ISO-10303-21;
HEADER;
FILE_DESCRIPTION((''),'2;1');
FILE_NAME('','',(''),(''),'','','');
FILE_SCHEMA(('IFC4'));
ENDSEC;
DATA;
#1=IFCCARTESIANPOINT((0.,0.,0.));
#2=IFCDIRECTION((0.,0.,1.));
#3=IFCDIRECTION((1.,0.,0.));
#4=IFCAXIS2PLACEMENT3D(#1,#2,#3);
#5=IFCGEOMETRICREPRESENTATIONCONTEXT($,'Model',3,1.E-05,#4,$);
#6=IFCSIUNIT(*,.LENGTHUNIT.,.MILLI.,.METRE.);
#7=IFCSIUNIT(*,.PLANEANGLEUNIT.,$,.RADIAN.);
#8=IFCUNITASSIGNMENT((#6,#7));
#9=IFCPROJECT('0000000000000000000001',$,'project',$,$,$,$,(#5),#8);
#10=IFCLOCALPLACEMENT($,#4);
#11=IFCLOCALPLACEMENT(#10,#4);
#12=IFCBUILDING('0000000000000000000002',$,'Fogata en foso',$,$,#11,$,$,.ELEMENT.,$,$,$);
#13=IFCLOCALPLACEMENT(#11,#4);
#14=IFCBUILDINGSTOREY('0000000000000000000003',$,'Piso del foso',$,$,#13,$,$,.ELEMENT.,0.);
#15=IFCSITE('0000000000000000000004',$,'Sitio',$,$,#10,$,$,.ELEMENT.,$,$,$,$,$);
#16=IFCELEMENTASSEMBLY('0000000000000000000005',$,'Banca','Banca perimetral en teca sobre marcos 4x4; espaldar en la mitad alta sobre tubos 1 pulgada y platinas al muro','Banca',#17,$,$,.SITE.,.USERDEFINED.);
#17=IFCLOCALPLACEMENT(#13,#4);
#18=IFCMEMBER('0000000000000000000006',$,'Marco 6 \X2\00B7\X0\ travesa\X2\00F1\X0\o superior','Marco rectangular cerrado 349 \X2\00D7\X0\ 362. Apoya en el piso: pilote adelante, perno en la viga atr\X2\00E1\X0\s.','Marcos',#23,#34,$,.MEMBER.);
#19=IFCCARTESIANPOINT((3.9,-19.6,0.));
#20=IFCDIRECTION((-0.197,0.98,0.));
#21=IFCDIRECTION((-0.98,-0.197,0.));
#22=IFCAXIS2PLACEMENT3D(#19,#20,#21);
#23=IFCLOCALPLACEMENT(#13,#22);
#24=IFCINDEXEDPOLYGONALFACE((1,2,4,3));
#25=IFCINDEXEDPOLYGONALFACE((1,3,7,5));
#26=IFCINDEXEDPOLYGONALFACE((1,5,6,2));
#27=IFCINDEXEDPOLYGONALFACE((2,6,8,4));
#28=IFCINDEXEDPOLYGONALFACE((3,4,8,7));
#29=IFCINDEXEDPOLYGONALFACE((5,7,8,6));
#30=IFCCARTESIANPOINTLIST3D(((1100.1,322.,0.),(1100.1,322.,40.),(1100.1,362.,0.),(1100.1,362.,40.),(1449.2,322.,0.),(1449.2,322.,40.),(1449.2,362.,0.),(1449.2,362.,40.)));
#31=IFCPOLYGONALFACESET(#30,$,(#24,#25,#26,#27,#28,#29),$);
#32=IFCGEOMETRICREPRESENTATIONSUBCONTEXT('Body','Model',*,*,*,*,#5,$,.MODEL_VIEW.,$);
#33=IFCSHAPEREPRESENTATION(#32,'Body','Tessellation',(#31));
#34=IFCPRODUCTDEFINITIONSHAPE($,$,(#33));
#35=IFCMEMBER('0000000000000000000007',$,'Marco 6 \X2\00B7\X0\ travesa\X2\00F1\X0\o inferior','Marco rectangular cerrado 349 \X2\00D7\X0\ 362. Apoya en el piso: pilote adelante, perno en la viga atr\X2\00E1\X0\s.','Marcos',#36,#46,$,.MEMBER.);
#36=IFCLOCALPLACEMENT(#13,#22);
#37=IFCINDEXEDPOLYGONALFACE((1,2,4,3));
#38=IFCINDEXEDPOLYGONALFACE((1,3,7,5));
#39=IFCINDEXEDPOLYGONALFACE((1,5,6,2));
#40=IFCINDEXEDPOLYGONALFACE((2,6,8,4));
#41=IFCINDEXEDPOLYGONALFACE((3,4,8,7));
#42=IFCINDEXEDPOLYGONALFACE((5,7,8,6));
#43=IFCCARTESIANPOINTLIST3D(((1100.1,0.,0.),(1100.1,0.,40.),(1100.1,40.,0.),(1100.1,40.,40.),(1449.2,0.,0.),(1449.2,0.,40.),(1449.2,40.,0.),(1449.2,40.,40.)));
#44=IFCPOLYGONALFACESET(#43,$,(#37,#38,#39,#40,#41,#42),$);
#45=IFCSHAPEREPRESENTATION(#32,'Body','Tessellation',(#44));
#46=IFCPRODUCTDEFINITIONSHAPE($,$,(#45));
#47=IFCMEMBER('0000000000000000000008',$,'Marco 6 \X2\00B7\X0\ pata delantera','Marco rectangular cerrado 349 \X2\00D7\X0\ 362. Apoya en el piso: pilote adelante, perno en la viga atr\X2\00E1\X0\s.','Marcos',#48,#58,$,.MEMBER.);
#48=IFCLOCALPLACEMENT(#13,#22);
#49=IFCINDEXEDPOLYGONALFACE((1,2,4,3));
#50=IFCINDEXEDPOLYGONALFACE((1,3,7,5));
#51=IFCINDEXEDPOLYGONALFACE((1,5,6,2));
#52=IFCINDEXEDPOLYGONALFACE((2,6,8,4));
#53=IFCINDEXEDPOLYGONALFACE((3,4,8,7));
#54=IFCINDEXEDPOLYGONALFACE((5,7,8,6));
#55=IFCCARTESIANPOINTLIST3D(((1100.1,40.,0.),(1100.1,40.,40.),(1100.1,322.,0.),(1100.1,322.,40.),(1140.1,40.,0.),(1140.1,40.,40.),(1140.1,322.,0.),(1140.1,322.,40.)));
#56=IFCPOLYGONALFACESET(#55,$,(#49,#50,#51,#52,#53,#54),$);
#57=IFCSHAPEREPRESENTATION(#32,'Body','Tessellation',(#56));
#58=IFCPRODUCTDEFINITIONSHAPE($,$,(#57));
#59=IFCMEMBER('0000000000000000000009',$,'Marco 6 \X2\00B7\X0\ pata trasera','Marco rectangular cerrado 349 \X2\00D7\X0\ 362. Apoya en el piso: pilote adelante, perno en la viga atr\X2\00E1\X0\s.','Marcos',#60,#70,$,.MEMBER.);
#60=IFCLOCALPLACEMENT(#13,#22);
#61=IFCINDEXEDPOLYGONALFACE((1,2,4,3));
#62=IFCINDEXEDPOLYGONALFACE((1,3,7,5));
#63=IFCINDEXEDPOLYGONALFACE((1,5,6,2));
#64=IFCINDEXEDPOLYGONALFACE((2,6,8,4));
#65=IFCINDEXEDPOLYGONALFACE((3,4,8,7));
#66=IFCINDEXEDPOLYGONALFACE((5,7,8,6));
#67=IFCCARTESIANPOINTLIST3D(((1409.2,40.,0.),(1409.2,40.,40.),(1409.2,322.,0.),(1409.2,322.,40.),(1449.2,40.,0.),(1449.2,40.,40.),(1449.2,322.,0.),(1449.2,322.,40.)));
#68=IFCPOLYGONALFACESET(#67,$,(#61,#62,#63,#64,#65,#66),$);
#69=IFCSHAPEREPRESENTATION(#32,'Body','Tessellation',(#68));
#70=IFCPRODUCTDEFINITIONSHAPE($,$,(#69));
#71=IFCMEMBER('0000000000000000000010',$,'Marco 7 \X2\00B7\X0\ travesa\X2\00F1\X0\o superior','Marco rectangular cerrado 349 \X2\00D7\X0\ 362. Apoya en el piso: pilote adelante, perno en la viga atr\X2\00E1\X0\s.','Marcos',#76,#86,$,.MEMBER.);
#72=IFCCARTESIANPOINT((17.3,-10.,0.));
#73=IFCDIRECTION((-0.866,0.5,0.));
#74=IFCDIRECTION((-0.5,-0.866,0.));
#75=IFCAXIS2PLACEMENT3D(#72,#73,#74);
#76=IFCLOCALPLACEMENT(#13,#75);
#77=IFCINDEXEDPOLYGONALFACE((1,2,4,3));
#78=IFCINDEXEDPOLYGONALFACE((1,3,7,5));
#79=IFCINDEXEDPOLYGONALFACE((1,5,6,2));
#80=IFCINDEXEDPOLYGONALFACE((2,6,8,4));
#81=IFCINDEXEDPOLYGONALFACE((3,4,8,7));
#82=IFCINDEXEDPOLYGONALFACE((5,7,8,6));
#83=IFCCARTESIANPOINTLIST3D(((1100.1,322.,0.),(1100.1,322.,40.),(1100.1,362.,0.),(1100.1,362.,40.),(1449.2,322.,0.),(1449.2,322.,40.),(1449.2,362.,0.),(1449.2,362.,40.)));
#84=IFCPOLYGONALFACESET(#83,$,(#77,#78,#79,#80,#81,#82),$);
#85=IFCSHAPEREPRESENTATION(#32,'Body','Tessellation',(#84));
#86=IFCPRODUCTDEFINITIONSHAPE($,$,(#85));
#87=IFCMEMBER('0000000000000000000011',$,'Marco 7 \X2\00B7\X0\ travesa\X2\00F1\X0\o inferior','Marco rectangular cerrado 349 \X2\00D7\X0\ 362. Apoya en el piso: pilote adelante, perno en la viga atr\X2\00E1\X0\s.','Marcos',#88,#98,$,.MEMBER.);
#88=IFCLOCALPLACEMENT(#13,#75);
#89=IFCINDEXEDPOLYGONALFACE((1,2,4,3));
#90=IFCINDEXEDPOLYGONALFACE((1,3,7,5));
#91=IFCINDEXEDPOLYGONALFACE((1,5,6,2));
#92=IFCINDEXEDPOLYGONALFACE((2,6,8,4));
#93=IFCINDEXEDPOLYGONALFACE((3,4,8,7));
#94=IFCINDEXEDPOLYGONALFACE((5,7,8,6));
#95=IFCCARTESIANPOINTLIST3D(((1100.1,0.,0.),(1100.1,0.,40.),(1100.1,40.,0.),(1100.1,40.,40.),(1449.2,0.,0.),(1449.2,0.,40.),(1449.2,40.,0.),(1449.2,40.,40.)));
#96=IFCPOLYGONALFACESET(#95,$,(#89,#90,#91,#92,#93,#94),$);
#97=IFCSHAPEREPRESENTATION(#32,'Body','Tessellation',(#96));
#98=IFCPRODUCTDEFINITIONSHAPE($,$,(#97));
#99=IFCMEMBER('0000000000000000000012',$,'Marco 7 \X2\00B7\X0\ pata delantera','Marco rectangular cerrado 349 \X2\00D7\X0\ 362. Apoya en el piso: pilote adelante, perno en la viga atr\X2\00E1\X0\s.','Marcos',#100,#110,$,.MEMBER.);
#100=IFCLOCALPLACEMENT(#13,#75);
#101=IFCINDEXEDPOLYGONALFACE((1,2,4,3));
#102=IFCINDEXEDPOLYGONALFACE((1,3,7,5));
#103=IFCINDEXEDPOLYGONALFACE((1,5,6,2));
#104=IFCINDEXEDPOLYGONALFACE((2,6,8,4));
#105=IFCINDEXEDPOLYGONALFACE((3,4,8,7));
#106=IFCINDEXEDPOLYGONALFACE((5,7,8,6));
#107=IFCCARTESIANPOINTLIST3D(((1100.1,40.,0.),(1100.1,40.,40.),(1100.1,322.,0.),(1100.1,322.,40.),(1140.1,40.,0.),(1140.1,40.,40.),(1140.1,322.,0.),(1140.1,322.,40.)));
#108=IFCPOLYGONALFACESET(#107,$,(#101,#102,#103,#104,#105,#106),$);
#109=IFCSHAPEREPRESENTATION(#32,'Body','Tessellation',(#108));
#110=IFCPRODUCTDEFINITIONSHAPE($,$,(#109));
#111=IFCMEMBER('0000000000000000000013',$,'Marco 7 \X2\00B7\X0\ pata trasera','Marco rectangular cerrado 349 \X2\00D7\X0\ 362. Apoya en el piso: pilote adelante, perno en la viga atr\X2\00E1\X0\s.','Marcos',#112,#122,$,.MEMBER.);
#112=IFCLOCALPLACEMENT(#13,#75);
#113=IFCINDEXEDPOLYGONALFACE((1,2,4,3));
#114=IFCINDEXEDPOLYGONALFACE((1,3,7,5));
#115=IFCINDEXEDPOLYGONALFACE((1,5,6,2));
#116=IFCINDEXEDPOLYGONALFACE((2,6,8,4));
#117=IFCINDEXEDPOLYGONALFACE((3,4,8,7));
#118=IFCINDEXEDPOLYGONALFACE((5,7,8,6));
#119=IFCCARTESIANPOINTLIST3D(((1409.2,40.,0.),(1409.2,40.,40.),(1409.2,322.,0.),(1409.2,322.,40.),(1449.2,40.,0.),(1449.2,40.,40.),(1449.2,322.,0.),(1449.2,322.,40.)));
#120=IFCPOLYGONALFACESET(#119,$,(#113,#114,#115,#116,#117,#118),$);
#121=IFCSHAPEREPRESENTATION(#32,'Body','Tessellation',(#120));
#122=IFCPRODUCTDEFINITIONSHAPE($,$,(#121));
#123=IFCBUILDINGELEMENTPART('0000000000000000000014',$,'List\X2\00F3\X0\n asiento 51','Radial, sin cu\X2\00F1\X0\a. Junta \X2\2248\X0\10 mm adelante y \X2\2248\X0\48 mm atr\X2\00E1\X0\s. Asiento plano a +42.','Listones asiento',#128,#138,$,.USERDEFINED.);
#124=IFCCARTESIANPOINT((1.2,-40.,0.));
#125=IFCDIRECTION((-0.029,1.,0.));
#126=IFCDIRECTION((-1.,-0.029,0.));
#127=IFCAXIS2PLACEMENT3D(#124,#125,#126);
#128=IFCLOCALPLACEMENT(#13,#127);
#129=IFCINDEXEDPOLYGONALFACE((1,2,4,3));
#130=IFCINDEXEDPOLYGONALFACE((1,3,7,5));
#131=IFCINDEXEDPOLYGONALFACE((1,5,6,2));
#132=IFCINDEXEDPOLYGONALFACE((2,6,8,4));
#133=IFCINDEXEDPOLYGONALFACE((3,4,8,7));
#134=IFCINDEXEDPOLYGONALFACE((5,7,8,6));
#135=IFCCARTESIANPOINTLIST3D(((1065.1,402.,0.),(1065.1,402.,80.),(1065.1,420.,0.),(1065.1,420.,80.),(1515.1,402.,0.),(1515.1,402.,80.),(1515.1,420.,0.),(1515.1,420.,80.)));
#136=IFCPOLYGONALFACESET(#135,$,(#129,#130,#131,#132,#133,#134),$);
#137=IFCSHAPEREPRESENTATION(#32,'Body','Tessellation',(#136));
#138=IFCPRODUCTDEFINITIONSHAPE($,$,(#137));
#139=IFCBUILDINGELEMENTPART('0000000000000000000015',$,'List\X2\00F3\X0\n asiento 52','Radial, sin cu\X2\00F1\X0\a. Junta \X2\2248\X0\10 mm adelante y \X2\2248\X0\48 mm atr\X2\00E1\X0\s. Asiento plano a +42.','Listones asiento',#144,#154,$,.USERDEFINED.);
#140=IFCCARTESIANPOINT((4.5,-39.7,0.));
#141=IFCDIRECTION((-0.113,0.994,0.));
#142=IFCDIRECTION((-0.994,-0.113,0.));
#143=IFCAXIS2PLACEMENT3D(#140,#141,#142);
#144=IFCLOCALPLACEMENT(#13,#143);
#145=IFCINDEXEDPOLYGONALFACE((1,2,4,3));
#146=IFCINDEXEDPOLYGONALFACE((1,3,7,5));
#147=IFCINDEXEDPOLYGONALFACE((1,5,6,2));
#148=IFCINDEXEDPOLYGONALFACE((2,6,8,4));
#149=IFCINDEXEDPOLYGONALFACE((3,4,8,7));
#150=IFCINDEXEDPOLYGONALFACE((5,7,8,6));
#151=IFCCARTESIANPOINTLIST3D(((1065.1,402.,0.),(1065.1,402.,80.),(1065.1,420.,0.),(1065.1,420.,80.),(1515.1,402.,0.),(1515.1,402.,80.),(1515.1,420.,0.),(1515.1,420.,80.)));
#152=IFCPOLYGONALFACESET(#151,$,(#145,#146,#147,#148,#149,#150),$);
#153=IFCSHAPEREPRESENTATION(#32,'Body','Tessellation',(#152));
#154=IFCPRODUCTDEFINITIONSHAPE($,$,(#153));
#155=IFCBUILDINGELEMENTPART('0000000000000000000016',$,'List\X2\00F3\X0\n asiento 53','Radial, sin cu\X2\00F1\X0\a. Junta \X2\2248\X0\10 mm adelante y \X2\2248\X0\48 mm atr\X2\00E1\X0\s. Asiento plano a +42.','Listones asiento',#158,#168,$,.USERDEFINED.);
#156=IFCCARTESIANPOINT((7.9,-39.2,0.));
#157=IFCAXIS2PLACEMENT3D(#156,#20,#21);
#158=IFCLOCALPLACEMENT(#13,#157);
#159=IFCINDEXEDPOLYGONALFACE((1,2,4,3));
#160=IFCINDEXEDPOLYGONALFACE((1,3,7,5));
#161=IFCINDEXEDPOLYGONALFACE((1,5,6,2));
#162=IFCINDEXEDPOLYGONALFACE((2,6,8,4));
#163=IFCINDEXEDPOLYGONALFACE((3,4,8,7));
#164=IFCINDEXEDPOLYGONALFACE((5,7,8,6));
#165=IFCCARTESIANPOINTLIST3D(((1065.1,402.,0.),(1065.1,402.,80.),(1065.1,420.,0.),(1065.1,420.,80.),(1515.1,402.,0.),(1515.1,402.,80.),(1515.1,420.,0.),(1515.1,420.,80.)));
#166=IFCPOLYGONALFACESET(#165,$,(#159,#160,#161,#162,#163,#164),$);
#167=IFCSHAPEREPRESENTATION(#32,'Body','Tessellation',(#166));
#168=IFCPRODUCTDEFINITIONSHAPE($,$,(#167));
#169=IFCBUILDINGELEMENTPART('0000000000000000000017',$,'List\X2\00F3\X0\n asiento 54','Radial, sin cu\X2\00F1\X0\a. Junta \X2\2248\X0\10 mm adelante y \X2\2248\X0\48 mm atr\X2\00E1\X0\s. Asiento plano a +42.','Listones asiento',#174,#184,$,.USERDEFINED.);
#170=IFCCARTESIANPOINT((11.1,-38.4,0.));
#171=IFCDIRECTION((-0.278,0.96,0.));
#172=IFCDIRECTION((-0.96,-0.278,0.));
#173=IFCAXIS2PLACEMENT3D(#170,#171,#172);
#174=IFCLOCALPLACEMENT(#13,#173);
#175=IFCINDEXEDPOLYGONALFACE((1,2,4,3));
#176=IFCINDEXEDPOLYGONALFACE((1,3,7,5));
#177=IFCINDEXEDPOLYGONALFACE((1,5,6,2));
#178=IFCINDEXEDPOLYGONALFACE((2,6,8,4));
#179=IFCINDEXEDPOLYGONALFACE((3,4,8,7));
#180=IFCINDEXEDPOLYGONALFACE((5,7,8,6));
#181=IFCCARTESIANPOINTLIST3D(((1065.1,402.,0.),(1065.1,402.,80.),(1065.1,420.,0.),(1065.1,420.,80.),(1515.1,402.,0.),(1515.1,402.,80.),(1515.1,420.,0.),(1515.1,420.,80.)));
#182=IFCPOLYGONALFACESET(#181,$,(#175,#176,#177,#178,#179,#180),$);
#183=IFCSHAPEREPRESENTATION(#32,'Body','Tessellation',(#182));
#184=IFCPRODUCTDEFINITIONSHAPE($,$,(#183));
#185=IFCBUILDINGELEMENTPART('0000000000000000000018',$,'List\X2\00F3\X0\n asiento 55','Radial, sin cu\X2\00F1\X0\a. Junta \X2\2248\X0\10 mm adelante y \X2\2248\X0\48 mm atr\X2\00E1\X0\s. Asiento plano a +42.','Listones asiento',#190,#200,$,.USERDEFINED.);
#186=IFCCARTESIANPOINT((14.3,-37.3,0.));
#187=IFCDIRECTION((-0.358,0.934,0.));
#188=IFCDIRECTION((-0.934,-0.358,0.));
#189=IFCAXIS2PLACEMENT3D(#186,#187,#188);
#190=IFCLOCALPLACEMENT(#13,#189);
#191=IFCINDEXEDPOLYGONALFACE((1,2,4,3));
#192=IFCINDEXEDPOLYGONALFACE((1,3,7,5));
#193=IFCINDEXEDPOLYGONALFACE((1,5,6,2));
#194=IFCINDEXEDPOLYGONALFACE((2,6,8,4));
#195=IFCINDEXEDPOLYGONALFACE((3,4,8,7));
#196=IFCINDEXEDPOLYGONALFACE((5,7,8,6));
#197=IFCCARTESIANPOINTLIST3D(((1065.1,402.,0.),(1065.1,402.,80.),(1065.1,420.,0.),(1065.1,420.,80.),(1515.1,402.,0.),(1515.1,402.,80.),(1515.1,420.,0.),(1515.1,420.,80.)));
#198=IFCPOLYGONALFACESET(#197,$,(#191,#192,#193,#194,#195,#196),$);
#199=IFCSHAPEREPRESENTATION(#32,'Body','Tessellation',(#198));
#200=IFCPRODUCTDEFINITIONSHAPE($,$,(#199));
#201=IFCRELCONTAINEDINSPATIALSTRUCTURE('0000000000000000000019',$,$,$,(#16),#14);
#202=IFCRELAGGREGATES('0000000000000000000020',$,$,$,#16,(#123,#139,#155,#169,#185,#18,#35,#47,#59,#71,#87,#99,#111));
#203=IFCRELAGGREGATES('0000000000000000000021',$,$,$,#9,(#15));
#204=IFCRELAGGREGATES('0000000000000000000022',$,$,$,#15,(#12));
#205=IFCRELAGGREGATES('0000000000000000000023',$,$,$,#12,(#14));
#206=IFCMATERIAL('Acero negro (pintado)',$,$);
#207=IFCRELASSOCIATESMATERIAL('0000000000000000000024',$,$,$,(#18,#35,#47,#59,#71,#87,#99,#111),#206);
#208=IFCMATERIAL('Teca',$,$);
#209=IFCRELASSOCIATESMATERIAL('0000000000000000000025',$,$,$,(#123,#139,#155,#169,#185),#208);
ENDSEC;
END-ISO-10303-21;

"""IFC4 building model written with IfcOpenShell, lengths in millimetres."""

from ifc_helpers import new_model, si_unit, frame, origin_with_axes, place, context, subcontext, project, spatial, polyline, outline, extrude, material, element, aggregate, save


model = new_model("IFC4")

# Units and contexts
model_context = context("Model", 3, precision=1e-05, world=origin_with_axes())
body_context = subcontext(model_context, "Body", "Model", "MODEL_VIEW")
ifc_project = project(units=[si_unit("LENGTHUNIT", "METRE", prefix="MILLI"), si_unit("PLANEANGLEUNIT", "RADIAN")], contexts=[model_context])

# Site, building, storey
site_placement = place(None, origin_with_axes())
site = spatial("IfcSite", under=ifc_project, at=site_placement, Name="Sitio", CompositionType="ELEMENT")
building_placement = place(site_placement, origin_with_axes())
building = spatial("IfcBuilding", under=site, at=building_placement, Name="Fogata en foso", CompositionType="ELEMENT")
storey_placement = place(building_placement, origin_with_axes())
storey = spatial("IfcBuildingStorey", under=building, at=storey_placement, Name="Piso del foso", CompositionType="ELEMENT", Elevation=0.0)

# Element assembly, members, building element parts
assembly_1_placement = place(storey_placement, origin_with_axes())
assembly_1 = element("IfcElementAssembly", 1, at=assembly_1_placement, inside=storey, Name="Banca", Description="Banca perimetral en teca sobre marcos 4x4; espaldar en la mitad alta sobre tubos 1 pulgada y platinas al muro", ObjectType="Banca", AssemblyPlace="SITE", PredefinedType="USERDEFINED")
ifc_material_1 = material(Name="Acero negro (pintado)")
member_1_placement = place(storey_placement, frame((3.9, -19.6, 0.0), z_axis=(-0.197, 0.98, 0.0), x_axis=(-0.98, -0.197, 0.0)))
member_1 = element("IfcMember", 2, at=member_1_placement, material=ifc_material_1, Name="Marco 6 · travesaño superior", Description="Marco rectangular cerrado 349 × 362. Apoya en el piso: pilote adelante, perno en la viga atrás.", ObjectType="Marcos", PredefinedType="MEMBER", context=body_context, shape_type="SweptSolid", body=[
    extrude(outline(polyline([(1100.1, 322.0), (1449.2, 322.0), (1449.2, 362.0), (1100.1, 362.0), (1100.1, 322.0)])), origin_with_axes(), (0.0, 0.0, 1.0), 40.0),
])
member_2_placement = place(storey_placement, frame((3.9, -19.6, 0.0), z_axis=(-0.197, 0.98, 0.0), x_axis=(-0.98, -0.197, 0.0)))
member_2 = element("IfcMember", 3, at=member_2_placement, material=ifc_material_1, Name="Marco 6 · travesaño inferior", Description="Marco rectangular cerrado 349 × 362. Apoya en el piso: pilote adelante, perno en la viga atrás.", ObjectType="Marcos", PredefinedType="MEMBER", context=body_context, shape_type="SweptSolid", body=[
    extrude(outline(polyline([(1100.1, 0.0), (1449.2, 0.0), (1449.2, 40.0), (1100.1, 40.0), (1100.1, 0.0)])), origin_with_axes(), (0.0, 0.0, 1.0), 40.0),
])
member_3_placement = place(storey_placement, frame((3.9, -19.6, 0.0), z_axis=(-0.197, 0.98, 0.0), x_axis=(-0.98, -0.197, 0.0)))
member_3 = element("IfcMember", 4, at=member_3_placement, material=ifc_material_1, Name="Marco 6 · pata delantera", Description="Marco rectangular cerrado 349 × 362. Apoya en el piso: pilote adelante, perno en la viga atrás.", ObjectType="Marcos", PredefinedType="MEMBER", context=body_context, shape_type="SweptSolid", body=[
    extrude(outline(polyline([(1100.1, 40.0), (1140.1, 40.0), (1140.1, 322.0), (1100.1, 322.0), (1100.1, 40.0)])), origin_with_axes(), (0.0, 0.0, 1.0), 40.0),
])
member_4_placement = place(storey_placement, frame((3.9, -19.6, 0.0), z_axis=(-0.197, 0.98, 0.0), x_axis=(-0.98, -0.197, 0.0)))
member_4 = element("IfcMember", 5, at=member_4_placement, material=ifc_material_1, Name="Marco 6 · pata trasera", Description="Marco rectangular cerrado 349 × 362. Apoya en el piso: pilote adelante, perno en la viga atrás.", ObjectType="Marcos", PredefinedType="MEMBER", context=body_context, shape_type="SweptSolid", body=[
    extrude(outline(polyline([(1409.2, 40.0), (1449.2, 40.0), (1449.2, 322.0), (1409.2, 322.0), (1409.2, 40.0)])), origin_with_axes(), (0.0, 0.0, 1.0), 40.0),
])
member_5_placement = place(storey_placement, frame((17.3, -10.0, 0.0), z_axis=(-0.866, 0.5, 0.0), x_axis=(-0.5, -0.866, 0.0)))
member_5 = element("IfcMember", 6, at=member_5_placement, material=ifc_material_1, Name="Marco 7 · travesaño superior", Description="Marco rectangular cerrado 349 × 362. Apoya en el piso: pilote adelante, perno en la viga atrás.", ObjectType="Marcos", PredefinedType="MEMBER", context=body_context, shape_type="SweptSolid", body=[
    extrude(outline(polyline([(1100.1, 322.0), (1449.2, 322.0), (1449.2, 362.0), (1100.1, 362.0), (1100.1, 322.0)])), origin_with_axes(), (0.0, 0.0, 1.0), 40.0),
])
member_6_placement = place(storey_placement, frame((17.3, -10.0, 0.0), z_axis=(-0.866, 0.5, 0.0), x_axis=(-0.5, -0.866, 0.0)))
member_6 = element("IfcMember", 7, at=member_6_placement, material=ifc_material_1, Name="Marco 7 · travesaño inferior", Description="Marco rectangular cerrado 349 × 362. Apoya en el piso: pilote adelante, perno en la viga atrás.", ObjectType="Marcos", PredefinedType="MEMBER", context=body_context, shape_type="SweptSolid", body=[
    extrude(outline(polyline([(1100.1, 0.0), (1449.2, 0.0), (1449.2, 40.0), (1100.1, 40.0), (1100.1, 0.0)])), origin_with_axes(), (0.0, 0.0, 1.0), 40.0),
])
member_7_placement = place(storey_placement, frame((17.3, -10.0, 0.0), z_axis=(-0.866, 0.5, 0.0), x_axis=(-0.5, -0.866, 0.0)))
member_7 = element("IfcMember", 8, at=member_7_placement, material=ifc_material_1, Name="Marco 7 · pata delantera", Description="Marco rectangular cerrado 349 × 362. Apoya en el piso: pilote adelante, perno en la viga atrás.", ObjectType="Marcos", PredefinedType="MEMBER", context=body_context, shape_type="SweptSolid", body=[
    extrude(outline(polyline([(1100.1, 40.0), (1140.1, 40.0), (1140.1, 322.0), (1100.1, 322.0), (1100.1, 40.0)])), origin_with_axes(), (0.0, 0.0, 1.0), 40.0),
])
member_8_placement = place(storey_placement, frame((17.3, -10.0, 0.0), z_axis=(-0.866, 0.5, 0.0), x_axis=(-0.5, -0.866, 0.0)))
member_8 = element("IfcMember", 9, at=member_8_placement, material=ifc_material_1, Name="Marco 7 · pata trasera", Description="Marco rectangular cerrado 349 × 362. Apoya en el piso: pilote adelante, perno en la viga atrás.", ObjectType="Marcos", PredefinedType="MEMBER", context=body_context, shape_type="SweptSolid", body=[
    extrude(outline(polyline([(1409.2, 40.0), (1449.2, 40.0), (1449.2, 322.0), (1409.2, 322.0), (1409.2, 40.0)])), origin_with_axes(), (0.0, 0.0, 1.0), 40.0),
])
ifc_material_2 = material(Name="Teca")
building_element_part_1_placement = place(storey_placement, frame((1.2, -40.0, 0.0), z_axis=(-0.029, 1.0, 0.0), x_axis=(-1.0, -0.029, 0.0)))
building_element_part_1 = element("IfcBuildingElementPart", 10, at=building_element_part_1_placement, material=ifc_material_2, Name="Listón asiento 51", Description="Radial, sin cuña. Junta ≈10 mm adelante y ≈48 mm atrás. Asiento plano a +42.", ObjectType="Listones asiento", PredefinedType="USERDEFINED", context=body_context, shape_type="SweptSolid", body=[
    extrude(outline(polyline([(1065.1, 402.0), (1515.1, 402.0), (1515.1, 420.0), (1065.1, 420.0), (1065.1, 402.0)])), origin_with_axes(), (0.0, 0.0, 1.0), 80.0),
])
building_element_part_2_placement = place(storey_placement, frame((4.5, -39.7, 0.0), z_axis=(-0.113, 0.994, 0.0), x_axis=(-0.994, -0.113, 0.0)))
building_element_part_2 = element("IfcBuildingElementPart", 11, at=building_element_part_2_placement, material=ifc_material_2, Name="Listón asiento 52", Description="Radial, sin cuña. Junta ≈10 mm adelante y ≈48 mm atrás. Asiento plano a +42.", ObjectType="Listones asiento", PredefinedType="USERDEFINED", context=body_context, shape_type="SweptSolid", body=[
    extrude(outline(polyline([(1065.1, 402.0), (1515.1, 402.0), (1515.1, 420.0), (1065.1, 420.0), (1065.1, 402.0)])), origin_with_axes(), (0.0, 0.0, 1.0), 80.0),
])
building_element_part_3_placement = place(storey_placement, frame((7.9, -39.2, 0.0), z_axis=(-0.197, 0.98, 0.0), x_axis=(-0.98, -0.197, 0.0)))
building_element_part_3 = element("IfcBuildingElementPart", 12, at=building_element_part_3_placement, material=ifc_material_2, Name="Listón asiento 53", Description="Radial, sin cuña. Junta ≈10 mm adelante y ≈48 mm atrás. Asiento plano a +42.", ObjectType="Listones asiento", PredefinedType="USERDEFINED", context=body_context, shape_type="SweptSolid", body=[
    extrude(outline(polyline([(1065.1, 402.0), (1515.1, 402.0), (1515.1, 420.0), (1065.1, 420.0), (1065.1, 402.0)])), origin_with_axes(), (0.0, 0.0, 1.0), 80.0),
])
building_element_part_4_placement = place(storey_placement, frame((11.1, -38.4, 0.0), z_axis=(-0.278, 0.96, 0.0), x_axis=(-0.96, -0.278, 0.0)))
building_element_part_4 = element("IfcBuildingElementPart", 13, at=building_element_part_4_placement, material=ifc_material_2, Name="Listón asiento 54", Description="Radial, sin cuña. Junta ≈10 mm adelante y ≈48 mm atrás. Asiento plano a +42.", ObjectType="Listones asiento", PredefinedType="USERDEFINED", context=body_context, shape_type="SweptSolid", body=[
    extrude(outline(polyline([(1065.1, 402.0), (1515.1, 402.0), (1515.1, 420.0), (1065.1, 420.0), (1065.1, 402.0)])), origin_with_axes(), (0.0, 0.0, 1.0), 80.0),
])
building_element_part_5_placement = place(storey_placement, frame((14.3, -37.3, 0.0), z_axis=(-0.358, 0.934, 0.0), x_axis=(-0.934, -0.358, 0.0)))
building_element_part_5 = element("IfcBuildingElementPart", 14, at=building_element_part_5_placement, material=ifc_material_2, Name="Listón asiento 55", Description="Radial, sin cuña. Junta ≈10 mm adelante y ≈48 mm atrás. Asiento plano a +42.", ObjectType="Listones asiento", PredefinedType="USERDEFINED", context=body_context, shape_type="SweptSolid", body=[
    extrude(outline(polyline([(1065.1, 402.0), (1515.1, 402.0), (1515.1, 420.0), (1065.1, 420.0), (1065.1, 402.0)])), origin_with_axes(), (0.0, 0.0, 1.0), 80.0),
])
aggregate(assembly_1, [building_element_part_1, building_element_part_2, building_element_part_3, building_element_part_4, building_element_part_5, member_1, member_2, member_3, member_4, member_5, member_6, member_7, member_8])

save(model, "model.ifc")
